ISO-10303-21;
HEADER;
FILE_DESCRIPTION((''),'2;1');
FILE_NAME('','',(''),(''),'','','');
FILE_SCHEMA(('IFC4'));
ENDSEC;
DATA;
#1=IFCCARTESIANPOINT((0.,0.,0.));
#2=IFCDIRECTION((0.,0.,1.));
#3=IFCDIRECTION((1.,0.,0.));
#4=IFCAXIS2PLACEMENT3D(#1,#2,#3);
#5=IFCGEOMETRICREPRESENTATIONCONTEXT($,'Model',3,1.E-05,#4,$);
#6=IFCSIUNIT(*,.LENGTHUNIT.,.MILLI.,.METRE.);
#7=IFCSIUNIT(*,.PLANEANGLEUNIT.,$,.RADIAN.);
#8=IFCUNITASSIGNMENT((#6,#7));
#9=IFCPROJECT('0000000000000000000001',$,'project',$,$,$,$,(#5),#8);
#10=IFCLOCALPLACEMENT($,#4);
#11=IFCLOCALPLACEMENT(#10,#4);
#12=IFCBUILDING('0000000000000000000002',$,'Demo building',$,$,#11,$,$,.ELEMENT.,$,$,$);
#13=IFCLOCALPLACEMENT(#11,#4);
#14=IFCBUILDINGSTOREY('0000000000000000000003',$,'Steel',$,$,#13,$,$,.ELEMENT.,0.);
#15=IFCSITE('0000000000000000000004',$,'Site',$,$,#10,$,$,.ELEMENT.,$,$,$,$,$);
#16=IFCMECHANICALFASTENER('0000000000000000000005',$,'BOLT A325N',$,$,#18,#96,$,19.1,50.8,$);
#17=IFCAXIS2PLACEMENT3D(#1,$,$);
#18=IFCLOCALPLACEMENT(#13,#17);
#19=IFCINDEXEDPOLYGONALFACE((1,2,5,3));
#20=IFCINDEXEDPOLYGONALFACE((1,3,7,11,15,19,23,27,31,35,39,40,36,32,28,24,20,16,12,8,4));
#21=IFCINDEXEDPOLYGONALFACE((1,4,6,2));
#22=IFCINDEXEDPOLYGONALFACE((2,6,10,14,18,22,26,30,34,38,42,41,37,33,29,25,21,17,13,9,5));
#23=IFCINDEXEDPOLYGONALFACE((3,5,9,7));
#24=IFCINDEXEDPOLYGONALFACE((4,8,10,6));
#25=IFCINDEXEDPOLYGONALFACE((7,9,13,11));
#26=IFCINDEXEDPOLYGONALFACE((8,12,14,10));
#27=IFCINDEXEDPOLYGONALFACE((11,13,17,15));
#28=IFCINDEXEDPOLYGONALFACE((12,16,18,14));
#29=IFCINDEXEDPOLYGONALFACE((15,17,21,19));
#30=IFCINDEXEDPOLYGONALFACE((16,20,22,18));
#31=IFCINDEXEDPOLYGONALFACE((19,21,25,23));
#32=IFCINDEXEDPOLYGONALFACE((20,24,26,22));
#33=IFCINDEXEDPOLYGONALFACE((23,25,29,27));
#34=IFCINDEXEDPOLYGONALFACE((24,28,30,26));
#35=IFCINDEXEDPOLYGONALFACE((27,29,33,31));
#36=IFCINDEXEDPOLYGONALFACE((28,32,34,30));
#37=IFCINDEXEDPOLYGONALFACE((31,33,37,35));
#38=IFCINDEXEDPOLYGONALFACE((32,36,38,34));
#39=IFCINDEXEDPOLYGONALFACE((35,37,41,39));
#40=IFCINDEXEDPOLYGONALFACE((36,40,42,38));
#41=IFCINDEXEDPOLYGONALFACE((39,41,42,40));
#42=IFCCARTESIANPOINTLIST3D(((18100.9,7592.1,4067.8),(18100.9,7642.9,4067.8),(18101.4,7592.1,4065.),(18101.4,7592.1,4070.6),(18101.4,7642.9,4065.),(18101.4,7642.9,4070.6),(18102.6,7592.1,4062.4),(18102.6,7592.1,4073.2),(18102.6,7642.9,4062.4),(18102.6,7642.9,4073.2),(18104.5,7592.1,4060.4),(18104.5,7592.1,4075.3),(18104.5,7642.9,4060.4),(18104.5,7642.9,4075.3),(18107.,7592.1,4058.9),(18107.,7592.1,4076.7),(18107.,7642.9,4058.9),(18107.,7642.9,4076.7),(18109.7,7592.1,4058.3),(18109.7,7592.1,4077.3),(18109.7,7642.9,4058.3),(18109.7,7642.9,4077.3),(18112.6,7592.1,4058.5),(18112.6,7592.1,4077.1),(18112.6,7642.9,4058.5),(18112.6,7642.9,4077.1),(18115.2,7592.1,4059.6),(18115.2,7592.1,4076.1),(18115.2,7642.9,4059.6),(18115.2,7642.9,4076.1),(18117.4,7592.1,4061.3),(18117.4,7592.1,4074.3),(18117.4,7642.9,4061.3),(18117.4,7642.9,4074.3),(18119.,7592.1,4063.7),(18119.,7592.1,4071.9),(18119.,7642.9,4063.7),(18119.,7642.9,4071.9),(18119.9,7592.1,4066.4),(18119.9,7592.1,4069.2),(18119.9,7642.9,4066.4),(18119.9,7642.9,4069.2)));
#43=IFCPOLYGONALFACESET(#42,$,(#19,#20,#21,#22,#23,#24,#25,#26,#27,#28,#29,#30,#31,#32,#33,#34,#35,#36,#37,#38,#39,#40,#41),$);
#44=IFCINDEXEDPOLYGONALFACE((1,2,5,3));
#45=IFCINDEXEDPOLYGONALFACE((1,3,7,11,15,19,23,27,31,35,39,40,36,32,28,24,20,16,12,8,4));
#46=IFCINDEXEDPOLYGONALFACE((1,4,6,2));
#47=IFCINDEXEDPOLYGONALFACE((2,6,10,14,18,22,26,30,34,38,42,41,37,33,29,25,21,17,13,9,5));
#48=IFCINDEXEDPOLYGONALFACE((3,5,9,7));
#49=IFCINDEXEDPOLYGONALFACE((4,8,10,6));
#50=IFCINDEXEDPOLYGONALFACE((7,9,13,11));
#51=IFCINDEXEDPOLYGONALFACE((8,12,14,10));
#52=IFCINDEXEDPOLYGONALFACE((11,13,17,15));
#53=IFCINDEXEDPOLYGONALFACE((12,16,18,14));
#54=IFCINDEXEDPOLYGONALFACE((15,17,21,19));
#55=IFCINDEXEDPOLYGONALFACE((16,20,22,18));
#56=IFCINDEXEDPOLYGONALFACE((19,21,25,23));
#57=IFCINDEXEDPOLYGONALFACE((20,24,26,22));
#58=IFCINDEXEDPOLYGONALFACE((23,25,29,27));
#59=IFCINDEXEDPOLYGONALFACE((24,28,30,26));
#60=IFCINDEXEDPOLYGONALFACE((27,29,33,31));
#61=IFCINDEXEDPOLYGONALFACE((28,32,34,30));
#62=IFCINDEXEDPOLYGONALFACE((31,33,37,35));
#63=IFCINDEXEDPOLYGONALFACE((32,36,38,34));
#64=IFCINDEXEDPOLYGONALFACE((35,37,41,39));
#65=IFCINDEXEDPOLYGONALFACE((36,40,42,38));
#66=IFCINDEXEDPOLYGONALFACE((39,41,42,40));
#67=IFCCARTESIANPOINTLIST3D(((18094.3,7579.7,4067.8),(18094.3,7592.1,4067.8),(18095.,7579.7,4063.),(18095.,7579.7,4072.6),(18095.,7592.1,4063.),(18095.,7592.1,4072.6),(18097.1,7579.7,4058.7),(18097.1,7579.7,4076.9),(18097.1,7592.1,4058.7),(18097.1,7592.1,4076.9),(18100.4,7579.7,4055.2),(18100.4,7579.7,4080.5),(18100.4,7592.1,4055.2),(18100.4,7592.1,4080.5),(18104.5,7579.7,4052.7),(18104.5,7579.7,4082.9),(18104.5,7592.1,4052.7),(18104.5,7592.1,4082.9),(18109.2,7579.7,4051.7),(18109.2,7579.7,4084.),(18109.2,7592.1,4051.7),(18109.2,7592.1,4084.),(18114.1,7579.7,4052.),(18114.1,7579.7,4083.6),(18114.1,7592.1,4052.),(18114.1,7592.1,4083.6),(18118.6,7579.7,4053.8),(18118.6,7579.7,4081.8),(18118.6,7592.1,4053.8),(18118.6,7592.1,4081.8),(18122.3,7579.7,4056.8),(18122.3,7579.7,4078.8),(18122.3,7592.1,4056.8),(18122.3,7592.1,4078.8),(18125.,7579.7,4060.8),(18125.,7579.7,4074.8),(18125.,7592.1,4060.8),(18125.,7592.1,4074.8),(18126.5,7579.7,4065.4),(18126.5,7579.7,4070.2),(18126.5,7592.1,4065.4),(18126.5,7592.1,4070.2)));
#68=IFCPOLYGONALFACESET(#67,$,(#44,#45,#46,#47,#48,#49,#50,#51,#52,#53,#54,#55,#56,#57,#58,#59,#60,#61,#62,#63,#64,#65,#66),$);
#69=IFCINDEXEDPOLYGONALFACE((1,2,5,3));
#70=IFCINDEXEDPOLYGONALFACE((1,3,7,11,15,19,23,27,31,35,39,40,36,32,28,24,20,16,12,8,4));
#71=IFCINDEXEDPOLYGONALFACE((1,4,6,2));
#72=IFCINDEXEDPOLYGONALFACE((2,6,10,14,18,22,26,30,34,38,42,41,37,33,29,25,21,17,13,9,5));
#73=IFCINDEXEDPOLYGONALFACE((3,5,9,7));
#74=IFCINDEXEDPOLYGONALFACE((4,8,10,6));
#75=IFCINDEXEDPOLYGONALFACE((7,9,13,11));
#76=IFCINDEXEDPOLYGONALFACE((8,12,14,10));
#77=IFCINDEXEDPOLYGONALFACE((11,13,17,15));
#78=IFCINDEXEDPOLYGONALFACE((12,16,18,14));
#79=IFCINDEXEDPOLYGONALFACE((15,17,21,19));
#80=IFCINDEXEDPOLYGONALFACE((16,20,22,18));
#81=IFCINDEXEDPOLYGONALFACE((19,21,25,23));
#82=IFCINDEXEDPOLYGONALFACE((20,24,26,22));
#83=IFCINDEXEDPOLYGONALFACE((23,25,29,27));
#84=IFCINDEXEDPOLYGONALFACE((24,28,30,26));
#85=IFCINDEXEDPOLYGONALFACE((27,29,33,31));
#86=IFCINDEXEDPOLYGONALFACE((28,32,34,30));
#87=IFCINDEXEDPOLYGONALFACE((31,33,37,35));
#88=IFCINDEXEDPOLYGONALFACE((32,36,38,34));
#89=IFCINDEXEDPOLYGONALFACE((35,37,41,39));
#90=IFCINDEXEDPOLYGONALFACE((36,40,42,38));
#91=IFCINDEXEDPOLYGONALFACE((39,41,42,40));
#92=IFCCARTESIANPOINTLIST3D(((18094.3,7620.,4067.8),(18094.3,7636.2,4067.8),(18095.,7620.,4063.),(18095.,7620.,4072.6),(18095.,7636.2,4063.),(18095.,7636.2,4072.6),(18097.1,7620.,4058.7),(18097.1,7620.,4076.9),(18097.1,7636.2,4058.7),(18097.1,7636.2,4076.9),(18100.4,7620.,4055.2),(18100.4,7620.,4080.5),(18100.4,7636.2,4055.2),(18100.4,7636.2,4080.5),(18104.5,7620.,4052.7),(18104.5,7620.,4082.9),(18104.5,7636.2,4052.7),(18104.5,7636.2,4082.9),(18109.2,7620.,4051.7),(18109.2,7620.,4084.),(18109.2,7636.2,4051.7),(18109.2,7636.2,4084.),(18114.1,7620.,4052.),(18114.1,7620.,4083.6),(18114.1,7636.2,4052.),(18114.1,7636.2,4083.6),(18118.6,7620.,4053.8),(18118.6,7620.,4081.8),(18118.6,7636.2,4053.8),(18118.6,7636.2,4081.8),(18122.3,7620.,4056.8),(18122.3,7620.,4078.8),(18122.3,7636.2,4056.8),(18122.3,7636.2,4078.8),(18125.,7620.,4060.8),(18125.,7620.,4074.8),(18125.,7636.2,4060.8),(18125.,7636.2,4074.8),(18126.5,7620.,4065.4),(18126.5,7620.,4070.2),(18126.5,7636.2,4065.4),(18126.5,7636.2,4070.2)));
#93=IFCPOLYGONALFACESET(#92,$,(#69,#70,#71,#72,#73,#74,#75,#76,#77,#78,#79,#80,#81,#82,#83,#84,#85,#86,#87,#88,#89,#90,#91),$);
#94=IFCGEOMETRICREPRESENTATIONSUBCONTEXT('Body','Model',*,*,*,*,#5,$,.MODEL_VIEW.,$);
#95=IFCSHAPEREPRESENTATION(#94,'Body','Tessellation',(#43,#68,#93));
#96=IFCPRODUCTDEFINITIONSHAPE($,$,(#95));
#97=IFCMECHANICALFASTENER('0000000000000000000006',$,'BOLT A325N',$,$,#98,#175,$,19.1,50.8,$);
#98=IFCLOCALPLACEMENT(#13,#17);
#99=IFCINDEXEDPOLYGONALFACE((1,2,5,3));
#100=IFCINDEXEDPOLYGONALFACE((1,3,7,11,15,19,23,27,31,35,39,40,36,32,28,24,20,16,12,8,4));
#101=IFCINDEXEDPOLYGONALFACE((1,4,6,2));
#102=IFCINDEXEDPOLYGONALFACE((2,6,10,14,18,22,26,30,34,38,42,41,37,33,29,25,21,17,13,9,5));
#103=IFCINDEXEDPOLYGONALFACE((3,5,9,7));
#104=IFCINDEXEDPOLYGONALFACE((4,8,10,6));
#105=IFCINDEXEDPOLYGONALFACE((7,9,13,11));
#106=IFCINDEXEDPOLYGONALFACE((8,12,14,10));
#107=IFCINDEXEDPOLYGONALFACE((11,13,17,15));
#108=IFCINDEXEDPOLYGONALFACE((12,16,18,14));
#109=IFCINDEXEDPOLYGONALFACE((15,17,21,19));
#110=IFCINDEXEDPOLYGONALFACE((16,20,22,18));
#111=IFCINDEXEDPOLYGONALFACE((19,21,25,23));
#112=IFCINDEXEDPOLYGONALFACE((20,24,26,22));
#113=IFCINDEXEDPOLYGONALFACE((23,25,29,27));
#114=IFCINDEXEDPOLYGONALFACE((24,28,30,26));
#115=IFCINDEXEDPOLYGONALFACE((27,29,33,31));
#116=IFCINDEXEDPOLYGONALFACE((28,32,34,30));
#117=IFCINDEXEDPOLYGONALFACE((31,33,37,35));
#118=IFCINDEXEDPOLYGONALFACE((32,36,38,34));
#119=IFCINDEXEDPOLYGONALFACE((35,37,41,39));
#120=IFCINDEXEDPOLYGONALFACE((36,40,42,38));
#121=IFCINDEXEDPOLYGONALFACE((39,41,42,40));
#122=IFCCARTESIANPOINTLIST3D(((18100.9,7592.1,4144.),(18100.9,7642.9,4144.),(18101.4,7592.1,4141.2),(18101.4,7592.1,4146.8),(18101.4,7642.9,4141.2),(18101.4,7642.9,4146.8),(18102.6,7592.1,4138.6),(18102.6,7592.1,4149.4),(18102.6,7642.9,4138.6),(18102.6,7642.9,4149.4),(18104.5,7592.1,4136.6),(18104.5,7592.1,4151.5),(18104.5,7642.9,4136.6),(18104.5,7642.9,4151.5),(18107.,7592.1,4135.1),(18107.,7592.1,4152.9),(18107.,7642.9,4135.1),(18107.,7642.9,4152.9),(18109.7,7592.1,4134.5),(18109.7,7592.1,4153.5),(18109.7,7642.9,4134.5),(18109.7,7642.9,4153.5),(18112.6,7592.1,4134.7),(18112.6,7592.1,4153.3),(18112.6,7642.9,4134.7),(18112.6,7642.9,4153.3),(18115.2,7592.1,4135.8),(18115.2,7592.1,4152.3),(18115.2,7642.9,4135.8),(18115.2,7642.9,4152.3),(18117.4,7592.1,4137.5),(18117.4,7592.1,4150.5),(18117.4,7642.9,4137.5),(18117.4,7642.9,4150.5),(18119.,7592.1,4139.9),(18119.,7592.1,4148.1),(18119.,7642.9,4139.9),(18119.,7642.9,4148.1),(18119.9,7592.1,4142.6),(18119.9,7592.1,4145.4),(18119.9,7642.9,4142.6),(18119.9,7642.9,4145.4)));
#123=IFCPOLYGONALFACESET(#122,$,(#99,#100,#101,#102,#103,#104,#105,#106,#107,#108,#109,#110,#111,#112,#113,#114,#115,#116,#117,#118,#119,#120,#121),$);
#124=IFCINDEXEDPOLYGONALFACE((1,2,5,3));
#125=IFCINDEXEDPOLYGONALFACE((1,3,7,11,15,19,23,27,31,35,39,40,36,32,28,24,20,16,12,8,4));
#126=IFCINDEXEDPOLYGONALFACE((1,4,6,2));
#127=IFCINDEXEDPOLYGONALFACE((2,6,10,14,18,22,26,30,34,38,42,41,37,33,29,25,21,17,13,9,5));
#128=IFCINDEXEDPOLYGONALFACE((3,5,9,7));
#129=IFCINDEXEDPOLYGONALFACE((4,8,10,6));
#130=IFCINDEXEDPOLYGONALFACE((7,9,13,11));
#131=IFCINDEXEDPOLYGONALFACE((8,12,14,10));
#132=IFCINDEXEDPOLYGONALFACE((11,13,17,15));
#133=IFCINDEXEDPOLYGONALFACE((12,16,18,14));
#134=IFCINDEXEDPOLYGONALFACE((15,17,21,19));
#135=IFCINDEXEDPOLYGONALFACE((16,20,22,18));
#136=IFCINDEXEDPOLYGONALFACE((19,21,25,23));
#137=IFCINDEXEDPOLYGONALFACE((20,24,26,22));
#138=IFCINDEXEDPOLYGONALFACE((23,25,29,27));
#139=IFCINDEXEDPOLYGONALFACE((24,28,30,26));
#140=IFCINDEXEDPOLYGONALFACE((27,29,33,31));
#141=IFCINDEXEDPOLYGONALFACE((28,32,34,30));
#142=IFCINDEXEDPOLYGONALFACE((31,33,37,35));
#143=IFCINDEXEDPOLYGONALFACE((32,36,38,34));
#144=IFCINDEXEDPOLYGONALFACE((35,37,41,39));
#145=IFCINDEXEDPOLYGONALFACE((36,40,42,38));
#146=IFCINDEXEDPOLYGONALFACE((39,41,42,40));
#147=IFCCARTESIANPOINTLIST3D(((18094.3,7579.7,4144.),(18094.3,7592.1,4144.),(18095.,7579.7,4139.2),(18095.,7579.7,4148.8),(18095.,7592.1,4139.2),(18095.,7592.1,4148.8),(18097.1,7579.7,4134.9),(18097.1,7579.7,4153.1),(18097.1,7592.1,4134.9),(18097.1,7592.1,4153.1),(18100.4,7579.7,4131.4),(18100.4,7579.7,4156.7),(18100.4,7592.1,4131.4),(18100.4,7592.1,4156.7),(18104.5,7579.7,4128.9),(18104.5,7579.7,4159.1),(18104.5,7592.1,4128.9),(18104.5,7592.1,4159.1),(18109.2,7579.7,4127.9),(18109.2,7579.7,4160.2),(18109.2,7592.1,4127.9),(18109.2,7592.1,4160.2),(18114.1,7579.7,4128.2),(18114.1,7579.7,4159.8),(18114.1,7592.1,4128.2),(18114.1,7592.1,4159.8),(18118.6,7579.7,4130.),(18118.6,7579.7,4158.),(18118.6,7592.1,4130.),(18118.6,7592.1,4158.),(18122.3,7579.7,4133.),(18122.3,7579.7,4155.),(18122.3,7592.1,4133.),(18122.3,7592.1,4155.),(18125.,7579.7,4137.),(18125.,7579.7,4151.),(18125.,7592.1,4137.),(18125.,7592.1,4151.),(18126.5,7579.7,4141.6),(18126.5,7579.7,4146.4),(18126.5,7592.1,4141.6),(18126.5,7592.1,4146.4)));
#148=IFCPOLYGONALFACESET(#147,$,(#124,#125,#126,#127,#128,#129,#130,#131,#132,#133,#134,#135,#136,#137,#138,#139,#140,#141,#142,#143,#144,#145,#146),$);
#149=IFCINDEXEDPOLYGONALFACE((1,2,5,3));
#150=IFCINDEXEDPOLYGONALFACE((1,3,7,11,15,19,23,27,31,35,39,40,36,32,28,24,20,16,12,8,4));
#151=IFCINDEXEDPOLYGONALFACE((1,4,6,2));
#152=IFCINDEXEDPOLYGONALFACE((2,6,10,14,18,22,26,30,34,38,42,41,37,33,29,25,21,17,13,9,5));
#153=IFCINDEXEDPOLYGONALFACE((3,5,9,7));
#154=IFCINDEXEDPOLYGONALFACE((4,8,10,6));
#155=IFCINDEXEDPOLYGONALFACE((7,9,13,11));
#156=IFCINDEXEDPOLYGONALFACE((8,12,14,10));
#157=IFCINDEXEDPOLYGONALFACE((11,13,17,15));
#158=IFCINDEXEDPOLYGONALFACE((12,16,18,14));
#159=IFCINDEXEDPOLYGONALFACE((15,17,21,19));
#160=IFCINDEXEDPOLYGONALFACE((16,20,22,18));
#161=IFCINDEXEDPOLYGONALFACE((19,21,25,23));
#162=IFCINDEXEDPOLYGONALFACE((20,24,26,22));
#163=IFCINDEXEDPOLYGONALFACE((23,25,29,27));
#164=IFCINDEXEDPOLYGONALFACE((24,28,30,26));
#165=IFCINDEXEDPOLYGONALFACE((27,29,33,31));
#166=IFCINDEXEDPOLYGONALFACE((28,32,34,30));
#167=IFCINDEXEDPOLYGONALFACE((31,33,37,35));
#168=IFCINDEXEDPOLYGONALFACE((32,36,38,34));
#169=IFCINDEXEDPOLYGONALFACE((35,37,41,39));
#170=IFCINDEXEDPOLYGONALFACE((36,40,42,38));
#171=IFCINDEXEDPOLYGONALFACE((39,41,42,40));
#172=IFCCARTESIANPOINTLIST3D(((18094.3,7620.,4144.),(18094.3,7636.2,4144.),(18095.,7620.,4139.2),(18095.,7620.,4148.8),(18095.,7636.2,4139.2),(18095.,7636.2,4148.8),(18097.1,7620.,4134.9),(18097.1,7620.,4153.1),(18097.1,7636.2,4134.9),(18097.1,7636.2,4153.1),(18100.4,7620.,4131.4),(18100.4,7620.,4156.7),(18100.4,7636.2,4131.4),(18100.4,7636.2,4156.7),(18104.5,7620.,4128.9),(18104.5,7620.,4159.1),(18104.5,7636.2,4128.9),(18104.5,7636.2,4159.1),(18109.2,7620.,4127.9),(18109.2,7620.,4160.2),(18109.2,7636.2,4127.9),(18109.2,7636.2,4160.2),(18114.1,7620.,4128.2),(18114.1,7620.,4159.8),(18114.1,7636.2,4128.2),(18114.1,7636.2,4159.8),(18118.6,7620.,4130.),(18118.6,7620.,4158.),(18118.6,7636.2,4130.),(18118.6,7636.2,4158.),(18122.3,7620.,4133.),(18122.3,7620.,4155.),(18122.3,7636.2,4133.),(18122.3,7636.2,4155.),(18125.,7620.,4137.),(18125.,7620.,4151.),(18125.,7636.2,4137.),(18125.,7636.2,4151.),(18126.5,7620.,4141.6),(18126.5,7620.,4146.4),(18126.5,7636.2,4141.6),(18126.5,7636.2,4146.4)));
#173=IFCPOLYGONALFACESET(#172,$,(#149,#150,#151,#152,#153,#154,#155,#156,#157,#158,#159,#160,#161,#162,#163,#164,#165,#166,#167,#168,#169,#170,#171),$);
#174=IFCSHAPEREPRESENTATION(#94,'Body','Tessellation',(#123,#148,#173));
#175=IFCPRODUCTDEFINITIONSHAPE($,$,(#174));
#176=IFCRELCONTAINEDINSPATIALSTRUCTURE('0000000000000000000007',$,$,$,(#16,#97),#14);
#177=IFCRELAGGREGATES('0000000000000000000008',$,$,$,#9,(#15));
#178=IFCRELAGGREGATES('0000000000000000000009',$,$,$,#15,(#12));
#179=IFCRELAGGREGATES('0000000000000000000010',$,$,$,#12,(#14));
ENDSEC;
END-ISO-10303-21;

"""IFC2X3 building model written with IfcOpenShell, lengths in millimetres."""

from ifc_helpers import new_model, si_unit, frame, origin, origin_with_axes, origin_2d, place, context, subcontext, project, spatial, circle, extrude, element, save


model = new_model("IFC2X3")

# Units and contexts
model_context = context("Model", 3, precision=1e-05, world=origin_with_axes())
body_context = subcontext(model_context, "Body", "Model", "MODEL_VIEW")
ifc_project = project(units=[si_unit("LENGTHUNIT", "METRE", prefix="MILLI"), si_unit("PLANEANGLEUNIT", "RADIAN")], contexts=[model_context])

# Site, building, storey
site_placement = place(None, origin_with_axes())
site = spatial("IfcSite", under=ifc_project, at=site_placement, Name="Site", CompositionType="ELEMENT")
building_placement = place(site_placement, origin_with_axes())
building = spatial("IfcBuilding", under=site, at=building_placement, Name="Demo building", CompositionType="ELEMENT")
placement = place(building_placement, origin_with_axes())
storey = spatial("IfcBuildingStorey", under=building, at=placement, Name="Steel", CompositionType="ELEMENT", Elevation=0.0)

# Mechanical fasteners
for number, where, z_axis, x_axis, name in (
    (1, (18110.5, 7592.1, 4067.8), (0.0, 1.0, 0.0), (-1.0, 0.0, 0.0), "BOLT A325N"),
    (2, (18110.5, 7592.1, 4144.0), (0.0, 1.0, 0.0), (-1.0, 0.0, 0.0), "BOLT A325N"),
):
    element("IfcMechanicalFastener", number, at=place(placement, frame(where, z_axis=z_axis, x_axis=x_axis)), inside=storey, Name=name, NominalDiameter=19.1, NominalLength=50.8, context=body_context, shape_type="SweptSolid", body=[
        extrude(circle(Radius=9.5, at=origin_2d()), origin(), (0.0, 0.0, 1.0), 50.8),
        extrude(circle(Radius=16.2, at=origin_2d()), frame((0.0, 0.0, -12.4)), (0.0, 0.0, 1.0), 12.4),
        extrude(circle(Radius=16.2, at=origin_2d()), frame((0.0, 0.0, 27.9)), (0.0, 0.0, 1.0), 16.2),
    ])

save(model, "model.ifc")
